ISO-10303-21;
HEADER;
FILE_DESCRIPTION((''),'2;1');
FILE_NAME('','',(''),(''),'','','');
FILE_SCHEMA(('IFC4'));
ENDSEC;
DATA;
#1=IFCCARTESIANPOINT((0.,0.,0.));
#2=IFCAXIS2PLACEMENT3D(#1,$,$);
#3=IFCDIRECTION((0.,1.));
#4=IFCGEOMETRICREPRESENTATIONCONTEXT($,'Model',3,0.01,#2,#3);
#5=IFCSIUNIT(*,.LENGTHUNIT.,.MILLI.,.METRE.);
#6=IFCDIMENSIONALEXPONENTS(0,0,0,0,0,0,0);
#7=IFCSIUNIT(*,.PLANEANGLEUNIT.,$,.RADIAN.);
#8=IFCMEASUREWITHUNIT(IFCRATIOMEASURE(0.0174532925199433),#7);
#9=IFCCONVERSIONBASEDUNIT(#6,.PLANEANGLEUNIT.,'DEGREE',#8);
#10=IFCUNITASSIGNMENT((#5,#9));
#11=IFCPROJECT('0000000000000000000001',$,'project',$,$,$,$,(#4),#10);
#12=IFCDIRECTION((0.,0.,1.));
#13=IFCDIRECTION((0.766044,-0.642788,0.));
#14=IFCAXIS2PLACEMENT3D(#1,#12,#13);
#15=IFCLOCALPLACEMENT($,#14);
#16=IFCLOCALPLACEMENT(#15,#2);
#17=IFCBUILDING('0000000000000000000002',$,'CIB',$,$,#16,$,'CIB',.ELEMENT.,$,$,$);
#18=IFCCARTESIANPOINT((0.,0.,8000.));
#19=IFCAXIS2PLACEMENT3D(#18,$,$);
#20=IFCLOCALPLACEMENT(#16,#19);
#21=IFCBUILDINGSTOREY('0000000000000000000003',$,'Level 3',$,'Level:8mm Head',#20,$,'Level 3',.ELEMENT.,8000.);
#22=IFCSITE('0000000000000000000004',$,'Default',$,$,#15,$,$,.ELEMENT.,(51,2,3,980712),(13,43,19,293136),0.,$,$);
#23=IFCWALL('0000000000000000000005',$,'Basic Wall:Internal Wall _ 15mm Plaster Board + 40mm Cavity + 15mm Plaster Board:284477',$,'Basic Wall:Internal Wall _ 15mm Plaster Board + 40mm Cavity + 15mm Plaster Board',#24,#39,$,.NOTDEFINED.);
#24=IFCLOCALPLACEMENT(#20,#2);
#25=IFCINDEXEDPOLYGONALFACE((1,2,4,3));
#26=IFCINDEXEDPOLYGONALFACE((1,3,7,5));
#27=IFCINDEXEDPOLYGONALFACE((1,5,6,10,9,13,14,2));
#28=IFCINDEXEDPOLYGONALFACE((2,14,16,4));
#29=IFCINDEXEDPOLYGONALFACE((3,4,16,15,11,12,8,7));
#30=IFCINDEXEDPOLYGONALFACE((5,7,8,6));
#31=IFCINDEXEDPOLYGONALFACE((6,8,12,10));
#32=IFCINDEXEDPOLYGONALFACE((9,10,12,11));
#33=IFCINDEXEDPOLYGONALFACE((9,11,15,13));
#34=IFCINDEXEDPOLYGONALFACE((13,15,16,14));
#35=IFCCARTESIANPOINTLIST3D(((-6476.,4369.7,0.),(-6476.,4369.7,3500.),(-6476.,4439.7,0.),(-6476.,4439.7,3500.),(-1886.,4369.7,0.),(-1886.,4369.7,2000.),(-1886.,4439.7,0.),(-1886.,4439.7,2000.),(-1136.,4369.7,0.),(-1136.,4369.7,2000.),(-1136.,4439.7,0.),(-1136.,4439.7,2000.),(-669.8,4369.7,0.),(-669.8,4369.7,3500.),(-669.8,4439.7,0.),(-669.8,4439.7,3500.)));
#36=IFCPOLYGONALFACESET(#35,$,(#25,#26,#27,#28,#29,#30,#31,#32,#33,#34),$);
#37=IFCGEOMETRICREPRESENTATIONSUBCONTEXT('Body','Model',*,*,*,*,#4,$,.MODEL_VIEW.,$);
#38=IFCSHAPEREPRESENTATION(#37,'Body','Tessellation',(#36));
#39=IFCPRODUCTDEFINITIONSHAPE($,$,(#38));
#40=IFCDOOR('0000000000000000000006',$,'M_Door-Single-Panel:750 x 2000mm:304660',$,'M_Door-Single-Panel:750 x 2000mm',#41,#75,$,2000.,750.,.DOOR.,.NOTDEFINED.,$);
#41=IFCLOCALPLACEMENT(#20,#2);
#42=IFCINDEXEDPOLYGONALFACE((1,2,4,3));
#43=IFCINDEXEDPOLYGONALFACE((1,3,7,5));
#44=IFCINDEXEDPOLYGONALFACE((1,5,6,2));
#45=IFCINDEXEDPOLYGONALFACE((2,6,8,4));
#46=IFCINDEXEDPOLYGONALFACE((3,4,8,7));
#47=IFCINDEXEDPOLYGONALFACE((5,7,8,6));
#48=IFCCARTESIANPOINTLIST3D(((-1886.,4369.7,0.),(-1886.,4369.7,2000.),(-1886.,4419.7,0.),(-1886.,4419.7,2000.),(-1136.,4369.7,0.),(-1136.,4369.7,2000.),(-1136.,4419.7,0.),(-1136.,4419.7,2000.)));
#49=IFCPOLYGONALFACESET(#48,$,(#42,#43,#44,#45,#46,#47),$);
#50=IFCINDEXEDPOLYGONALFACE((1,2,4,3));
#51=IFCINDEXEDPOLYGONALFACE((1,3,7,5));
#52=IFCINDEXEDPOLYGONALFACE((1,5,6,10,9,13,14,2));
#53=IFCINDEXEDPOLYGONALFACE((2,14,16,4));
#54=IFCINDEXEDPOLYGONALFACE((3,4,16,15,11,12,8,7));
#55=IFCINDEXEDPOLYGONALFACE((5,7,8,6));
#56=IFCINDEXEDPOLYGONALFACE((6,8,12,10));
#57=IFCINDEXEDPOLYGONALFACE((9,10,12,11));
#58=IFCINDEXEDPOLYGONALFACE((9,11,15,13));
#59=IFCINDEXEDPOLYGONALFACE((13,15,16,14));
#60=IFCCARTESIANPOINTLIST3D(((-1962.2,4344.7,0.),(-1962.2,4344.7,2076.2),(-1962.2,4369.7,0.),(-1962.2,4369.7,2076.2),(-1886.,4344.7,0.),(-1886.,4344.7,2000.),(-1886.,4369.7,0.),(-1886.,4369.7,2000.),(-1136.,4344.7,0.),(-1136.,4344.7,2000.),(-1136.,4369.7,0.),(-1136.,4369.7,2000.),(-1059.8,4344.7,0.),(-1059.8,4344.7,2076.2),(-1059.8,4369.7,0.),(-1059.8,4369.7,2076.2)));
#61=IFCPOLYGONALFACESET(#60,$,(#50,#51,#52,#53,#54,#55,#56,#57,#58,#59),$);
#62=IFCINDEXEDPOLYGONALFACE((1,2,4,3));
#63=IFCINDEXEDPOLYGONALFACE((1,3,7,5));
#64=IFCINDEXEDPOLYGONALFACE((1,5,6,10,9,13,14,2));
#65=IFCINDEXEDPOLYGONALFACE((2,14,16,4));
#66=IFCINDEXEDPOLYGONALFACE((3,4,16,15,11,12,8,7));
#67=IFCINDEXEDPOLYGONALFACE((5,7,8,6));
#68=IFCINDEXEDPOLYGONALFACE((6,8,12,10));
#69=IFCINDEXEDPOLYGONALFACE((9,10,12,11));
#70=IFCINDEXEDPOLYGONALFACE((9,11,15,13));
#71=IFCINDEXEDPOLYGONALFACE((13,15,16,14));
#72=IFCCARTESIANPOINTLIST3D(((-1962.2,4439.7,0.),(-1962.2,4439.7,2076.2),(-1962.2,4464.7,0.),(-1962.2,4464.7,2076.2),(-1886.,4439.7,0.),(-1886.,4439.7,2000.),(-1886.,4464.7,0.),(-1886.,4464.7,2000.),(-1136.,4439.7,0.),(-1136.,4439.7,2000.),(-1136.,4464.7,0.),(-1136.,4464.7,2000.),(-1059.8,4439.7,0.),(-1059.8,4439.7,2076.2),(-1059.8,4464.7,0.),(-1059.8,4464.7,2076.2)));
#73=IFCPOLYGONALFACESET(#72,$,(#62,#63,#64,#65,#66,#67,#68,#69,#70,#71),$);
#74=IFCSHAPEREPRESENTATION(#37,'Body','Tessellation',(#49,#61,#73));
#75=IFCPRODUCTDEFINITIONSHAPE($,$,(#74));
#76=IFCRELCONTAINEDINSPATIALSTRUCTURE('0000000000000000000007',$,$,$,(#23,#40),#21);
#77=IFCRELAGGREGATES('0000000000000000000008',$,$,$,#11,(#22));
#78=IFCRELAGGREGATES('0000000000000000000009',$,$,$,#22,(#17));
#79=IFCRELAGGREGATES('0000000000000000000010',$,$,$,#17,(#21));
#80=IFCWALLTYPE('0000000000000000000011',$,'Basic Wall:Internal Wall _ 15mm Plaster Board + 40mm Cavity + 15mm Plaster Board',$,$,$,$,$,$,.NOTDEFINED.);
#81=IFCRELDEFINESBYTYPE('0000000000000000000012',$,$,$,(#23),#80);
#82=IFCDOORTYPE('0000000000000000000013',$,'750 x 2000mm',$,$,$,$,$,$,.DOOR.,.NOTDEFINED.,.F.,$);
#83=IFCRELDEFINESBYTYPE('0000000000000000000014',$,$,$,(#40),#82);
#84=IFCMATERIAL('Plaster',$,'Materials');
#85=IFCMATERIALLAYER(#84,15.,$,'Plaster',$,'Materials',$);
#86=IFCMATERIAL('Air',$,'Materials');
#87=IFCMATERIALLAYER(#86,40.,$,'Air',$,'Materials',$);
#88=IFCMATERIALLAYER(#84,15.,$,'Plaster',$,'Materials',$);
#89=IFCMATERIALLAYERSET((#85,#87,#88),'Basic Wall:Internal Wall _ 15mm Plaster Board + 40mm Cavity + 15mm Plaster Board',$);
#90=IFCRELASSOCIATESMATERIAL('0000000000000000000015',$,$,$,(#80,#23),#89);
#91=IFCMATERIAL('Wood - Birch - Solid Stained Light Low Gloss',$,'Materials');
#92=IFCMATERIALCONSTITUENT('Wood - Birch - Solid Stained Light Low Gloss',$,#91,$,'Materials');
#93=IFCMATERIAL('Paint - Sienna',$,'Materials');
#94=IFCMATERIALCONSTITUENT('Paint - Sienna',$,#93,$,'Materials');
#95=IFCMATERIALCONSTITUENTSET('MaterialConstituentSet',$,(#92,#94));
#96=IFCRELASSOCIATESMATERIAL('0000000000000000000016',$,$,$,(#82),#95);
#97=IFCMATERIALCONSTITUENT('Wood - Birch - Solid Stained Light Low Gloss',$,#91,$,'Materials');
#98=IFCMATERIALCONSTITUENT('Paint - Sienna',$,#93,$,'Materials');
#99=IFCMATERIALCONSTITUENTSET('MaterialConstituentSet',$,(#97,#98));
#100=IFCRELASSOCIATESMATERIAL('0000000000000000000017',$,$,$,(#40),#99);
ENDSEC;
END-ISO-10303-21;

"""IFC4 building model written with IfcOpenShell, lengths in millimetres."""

from ifc_helpers import new_model, entity, si_unit, converted_unit, direction, frame, frame_2d, origin, origin_2d_with_axis, place, context, subcontext, project, spatial, polyline, rectangle, outline, extrude, source, transform, mapped, material, layer, layer_set, layer_usage, constituent, constituent_set, type_object, type_shapes, element, fill, save


model = new_model("IFC4")

# Units and contexts
model_context = context("Model", 3, precision=0.01, world=origin(), true_north=direction((0.0, 1.0)))
body_context = subcontext(model_context, "Body", "Model", "MODEL_VIEW")
ifc_project = project(units=[si_unit("LENGTHUNIT", "METRE", prefix="MILLI"), converted_unit("PLANEANGLEUNIT", "DEGREE", entity("IfcRatioMeasure", 0.0174532925199433), si_unit("PLANEANGLEUNIT", "RADIAN"), dimensions=[0, 0, 0, 0, 0, 0, 0])], contexts=[model_context])

# Site, building, storey
site_placement = place(None, frame((0.0, 0.0, 0.0), z_axis=(0.0, 0.0, 1.0), x_axis=(0.766044, -0.642788, 0.0)))
site = spatial("IfcSite", under=ifc_project, at=site_placement, Name="Default", CompositionType="ELEMENT", RefLatitude=(51, 2, 3, 980712), RefLongitude=(13, 43, 19, 293136), RefElevation=0.0)
building_placement = place(site_placement, origin())
building = spatial("IfcBuilding", under=site, at=building_placement, Name="CIB", LongName="CIB", CompositionType="ELEMENT")
storey_placement = place(building_placement, frame((0.0, 0.0, 8000.0)))
storey = spatial("IfcBuildingStorey", under=building, at=storey_placement, Name="Level 3", ObjectType="Level:8mm Head", LongName="Level 3", CompositionType="ELEMENT", Elevation=8000.0)

# Shared definitions
ifc_material_1 = material(Name="Plaster", Category="Materials")

# Shared definitions
ifc_layer_1 = layer(ifc_material_1, 15.0, Name="Plaster", Category="Materials")
ifc_material_2 = material(Name="Air", Category="Materials")
ifc_layer_2 = layer(ifc_material_2, 40.0, Name="Air", Category="Materials")
ifc_layer_3 = layer(ifc_material_1, 15.0, Name="Plaster", Category="Materials")
ifc_layer_set_1 = layer_set([ifc_layer_1, ifc_layer_2, ifc_layer_3], Name="Basic Wall:Internal Wall _ 15mm Plaster Board + 40mm Cavity + 15mm Plaster Board")
wall_type_1 = type_object("IfcWallType", Name="Basic Wall:Internal Wall _ 15mm Plaster Board + 40mm Cavity + 15mm Plaster Board", PredefinedType="NOTDEFINED", material=ifc_layer_set_1)

# Shared definitions
ifc_material_3 = material(Name="Wood - Birch - Solid Stained Light Low Gloss", Category="Materials")
ifc_material_4 = material(Name="Paint - Sienna", Category="Materials")
ifc_constituent_1 = constituent(ifc_material_3, Name="Wood - Birch - Solid Stained Light Low Gloss", Category="Materials")
ifc_constituent_2 = constituent(ifc_material_4, Name="Paint - Sienna", Category="Materials")
ifc_constituent_set_1 = constituent_set(constituents=[ifc_constituent_1, ifc_constituent_2], Name="MaterialConstituentSet")
door_type = type_object("IfcDoorType", Name="750 x 2000mm", OperationType="NOTDEFINED", ParameterTakesPrecedence=False, PredefinedType="DOOR", material=ifc_constituent_set_1)
shared_shape = source(origin(), body_context, "Body", "SweptSolid", [
    extrude(rectangle(XDim=750.0, YDim=50.0, at=origin_2d_with_axis()), frame((375.0, 45.0, 0.0)), (0.0, 0.0, 1.0), 2000.0),
    extrude(outline(polyline([(-451.2, -1057.2), (451.2, -1057.2), (451.2, 1019.0), (375.0, 1019.0), (375.0, -981.0), (-375.0, -981.0), (-375.0, 1019.0), (-451.2, 1019.0), (-451.2, -1057.2)])), frame((375.0, 95.0, 1019.0), z_axis=(0.0, -1.0, 0.0), x_axis=(-1.0, 0.0, 0.0)), (0.0, 0.0, 1.0), 25.0),
    extrude(outline(polyline([(-1057.2, -451.2), (1019.0, -451.2), (1019.0, -375.0), (-981.0, -375.0), (-981.0, 375.0), (1019.0, 375.0), (1019.0, 451.2), (-1057.2, 451.2), (-1057.2, -451.2)])), frame((375.0, 0.0, 1019.0), z_axis=(0.0, -1.0, 0.0), x_axis=(0.0, 0.0, -1.0)), (0.0, 0.0, 1.0), 25.0),
])
type_shapes(door_type, [shared_shape])

# Wall, opening, door
ifc_layer_usage_1 = layer_usage(ifc_layer_set_1, "AXIS2", "NEGATIVE", 35.0)
wall_1_placement = place(storey_placement, frame((-6476.0, 4404.7, 0.0)))
wall_1 = element("IfcWall", 1, at=wall_1_placement, inside=storey, type_object=wall_type_1, material=ifc_layer_usage_1, Name="Basic Wall:Internal Wall _ 15mm Plaster Board + 40mm Cavity + 15mm Plaster Board:284477", ObjectType="Basic Wall:Internal Wall _ 15mm Plaster Board + 40mm Cavity + 15mm Plaster Board", PredefinedType="NOTDEFINED", context=body_context, shape_type="SweptSolid", body=[
    extrude(rectangle(XDim=5806.2, YDim=70.0, at=frame_2d((2903.1, 0.0), x_axis=(-1.0, 0.0))), origin(), (0.0, 0.0, 1.0), 3500.0),
])
opening_1_placement = place(wall_1_placement, frame((5340.0, 35.0, 0.0)))
opening_1 = element("IfcOpeningElement", 2, at=opening_1_placement, cuts=wall_1, ObjectType="Opening", PredefinedType="OPENING", context=body_context, shape_type="SweptSolid", body=[
    extrude(rectangle(XDim=750.0, YDim=2000.0, at=frame_2d((1000.0, 375.0), x_axis=(0.0, -1.0))), frame((0.0, 0.0, 0.0), z_axis=(0.0, -1.0, 0.0), x_axis=(0.0, 0.0, 1.0)), (0.0, 0.0, 1.0), 70.0),
])
ifc_constituent_3 = constituent(ifc_material_3, Name="Wood - Birch - Solid Stained Light Low Gloss", Category="Materials")
ifc_constituent_4 = constituent(ifc_material_4, Name="Paint - Sienna", Category="Materials")
ifc_constituent_set_2 = constituent_set(constituents=[ifc_constituent_3, ifc_constituent_4], Name="MaterialConstituentSet")
door_1_placement = place(opening_1_placement, frame((0.0, 0.0, 0.0), z_axis=(0.0, 0.0, 1.0), x_axis=(-1.0, 0.0, 0.0)))
door_1 = element("IfcDoor", 3, at=door_1_placement, inside=storey, type_object=door_type, material=ifc_constituent_set_2, Name="M_Door-Single-Panel:750 x 2000mm:304660", ObjectType="M_Door-Single-Panel:750 x 2000mm", OperationType="NOTDEFINED", OverallHeight=2000.0, OverallWidth=750.0, PredefinedType="DOOR", context=body_context, shape_type="MappedRepresentation", body=[
    mapped(shared_shape, transform((0.0, 0.0, 0.0), scale=1.0)),
])
fill(opening_1, door_1)

save(model, "model.ifc")
